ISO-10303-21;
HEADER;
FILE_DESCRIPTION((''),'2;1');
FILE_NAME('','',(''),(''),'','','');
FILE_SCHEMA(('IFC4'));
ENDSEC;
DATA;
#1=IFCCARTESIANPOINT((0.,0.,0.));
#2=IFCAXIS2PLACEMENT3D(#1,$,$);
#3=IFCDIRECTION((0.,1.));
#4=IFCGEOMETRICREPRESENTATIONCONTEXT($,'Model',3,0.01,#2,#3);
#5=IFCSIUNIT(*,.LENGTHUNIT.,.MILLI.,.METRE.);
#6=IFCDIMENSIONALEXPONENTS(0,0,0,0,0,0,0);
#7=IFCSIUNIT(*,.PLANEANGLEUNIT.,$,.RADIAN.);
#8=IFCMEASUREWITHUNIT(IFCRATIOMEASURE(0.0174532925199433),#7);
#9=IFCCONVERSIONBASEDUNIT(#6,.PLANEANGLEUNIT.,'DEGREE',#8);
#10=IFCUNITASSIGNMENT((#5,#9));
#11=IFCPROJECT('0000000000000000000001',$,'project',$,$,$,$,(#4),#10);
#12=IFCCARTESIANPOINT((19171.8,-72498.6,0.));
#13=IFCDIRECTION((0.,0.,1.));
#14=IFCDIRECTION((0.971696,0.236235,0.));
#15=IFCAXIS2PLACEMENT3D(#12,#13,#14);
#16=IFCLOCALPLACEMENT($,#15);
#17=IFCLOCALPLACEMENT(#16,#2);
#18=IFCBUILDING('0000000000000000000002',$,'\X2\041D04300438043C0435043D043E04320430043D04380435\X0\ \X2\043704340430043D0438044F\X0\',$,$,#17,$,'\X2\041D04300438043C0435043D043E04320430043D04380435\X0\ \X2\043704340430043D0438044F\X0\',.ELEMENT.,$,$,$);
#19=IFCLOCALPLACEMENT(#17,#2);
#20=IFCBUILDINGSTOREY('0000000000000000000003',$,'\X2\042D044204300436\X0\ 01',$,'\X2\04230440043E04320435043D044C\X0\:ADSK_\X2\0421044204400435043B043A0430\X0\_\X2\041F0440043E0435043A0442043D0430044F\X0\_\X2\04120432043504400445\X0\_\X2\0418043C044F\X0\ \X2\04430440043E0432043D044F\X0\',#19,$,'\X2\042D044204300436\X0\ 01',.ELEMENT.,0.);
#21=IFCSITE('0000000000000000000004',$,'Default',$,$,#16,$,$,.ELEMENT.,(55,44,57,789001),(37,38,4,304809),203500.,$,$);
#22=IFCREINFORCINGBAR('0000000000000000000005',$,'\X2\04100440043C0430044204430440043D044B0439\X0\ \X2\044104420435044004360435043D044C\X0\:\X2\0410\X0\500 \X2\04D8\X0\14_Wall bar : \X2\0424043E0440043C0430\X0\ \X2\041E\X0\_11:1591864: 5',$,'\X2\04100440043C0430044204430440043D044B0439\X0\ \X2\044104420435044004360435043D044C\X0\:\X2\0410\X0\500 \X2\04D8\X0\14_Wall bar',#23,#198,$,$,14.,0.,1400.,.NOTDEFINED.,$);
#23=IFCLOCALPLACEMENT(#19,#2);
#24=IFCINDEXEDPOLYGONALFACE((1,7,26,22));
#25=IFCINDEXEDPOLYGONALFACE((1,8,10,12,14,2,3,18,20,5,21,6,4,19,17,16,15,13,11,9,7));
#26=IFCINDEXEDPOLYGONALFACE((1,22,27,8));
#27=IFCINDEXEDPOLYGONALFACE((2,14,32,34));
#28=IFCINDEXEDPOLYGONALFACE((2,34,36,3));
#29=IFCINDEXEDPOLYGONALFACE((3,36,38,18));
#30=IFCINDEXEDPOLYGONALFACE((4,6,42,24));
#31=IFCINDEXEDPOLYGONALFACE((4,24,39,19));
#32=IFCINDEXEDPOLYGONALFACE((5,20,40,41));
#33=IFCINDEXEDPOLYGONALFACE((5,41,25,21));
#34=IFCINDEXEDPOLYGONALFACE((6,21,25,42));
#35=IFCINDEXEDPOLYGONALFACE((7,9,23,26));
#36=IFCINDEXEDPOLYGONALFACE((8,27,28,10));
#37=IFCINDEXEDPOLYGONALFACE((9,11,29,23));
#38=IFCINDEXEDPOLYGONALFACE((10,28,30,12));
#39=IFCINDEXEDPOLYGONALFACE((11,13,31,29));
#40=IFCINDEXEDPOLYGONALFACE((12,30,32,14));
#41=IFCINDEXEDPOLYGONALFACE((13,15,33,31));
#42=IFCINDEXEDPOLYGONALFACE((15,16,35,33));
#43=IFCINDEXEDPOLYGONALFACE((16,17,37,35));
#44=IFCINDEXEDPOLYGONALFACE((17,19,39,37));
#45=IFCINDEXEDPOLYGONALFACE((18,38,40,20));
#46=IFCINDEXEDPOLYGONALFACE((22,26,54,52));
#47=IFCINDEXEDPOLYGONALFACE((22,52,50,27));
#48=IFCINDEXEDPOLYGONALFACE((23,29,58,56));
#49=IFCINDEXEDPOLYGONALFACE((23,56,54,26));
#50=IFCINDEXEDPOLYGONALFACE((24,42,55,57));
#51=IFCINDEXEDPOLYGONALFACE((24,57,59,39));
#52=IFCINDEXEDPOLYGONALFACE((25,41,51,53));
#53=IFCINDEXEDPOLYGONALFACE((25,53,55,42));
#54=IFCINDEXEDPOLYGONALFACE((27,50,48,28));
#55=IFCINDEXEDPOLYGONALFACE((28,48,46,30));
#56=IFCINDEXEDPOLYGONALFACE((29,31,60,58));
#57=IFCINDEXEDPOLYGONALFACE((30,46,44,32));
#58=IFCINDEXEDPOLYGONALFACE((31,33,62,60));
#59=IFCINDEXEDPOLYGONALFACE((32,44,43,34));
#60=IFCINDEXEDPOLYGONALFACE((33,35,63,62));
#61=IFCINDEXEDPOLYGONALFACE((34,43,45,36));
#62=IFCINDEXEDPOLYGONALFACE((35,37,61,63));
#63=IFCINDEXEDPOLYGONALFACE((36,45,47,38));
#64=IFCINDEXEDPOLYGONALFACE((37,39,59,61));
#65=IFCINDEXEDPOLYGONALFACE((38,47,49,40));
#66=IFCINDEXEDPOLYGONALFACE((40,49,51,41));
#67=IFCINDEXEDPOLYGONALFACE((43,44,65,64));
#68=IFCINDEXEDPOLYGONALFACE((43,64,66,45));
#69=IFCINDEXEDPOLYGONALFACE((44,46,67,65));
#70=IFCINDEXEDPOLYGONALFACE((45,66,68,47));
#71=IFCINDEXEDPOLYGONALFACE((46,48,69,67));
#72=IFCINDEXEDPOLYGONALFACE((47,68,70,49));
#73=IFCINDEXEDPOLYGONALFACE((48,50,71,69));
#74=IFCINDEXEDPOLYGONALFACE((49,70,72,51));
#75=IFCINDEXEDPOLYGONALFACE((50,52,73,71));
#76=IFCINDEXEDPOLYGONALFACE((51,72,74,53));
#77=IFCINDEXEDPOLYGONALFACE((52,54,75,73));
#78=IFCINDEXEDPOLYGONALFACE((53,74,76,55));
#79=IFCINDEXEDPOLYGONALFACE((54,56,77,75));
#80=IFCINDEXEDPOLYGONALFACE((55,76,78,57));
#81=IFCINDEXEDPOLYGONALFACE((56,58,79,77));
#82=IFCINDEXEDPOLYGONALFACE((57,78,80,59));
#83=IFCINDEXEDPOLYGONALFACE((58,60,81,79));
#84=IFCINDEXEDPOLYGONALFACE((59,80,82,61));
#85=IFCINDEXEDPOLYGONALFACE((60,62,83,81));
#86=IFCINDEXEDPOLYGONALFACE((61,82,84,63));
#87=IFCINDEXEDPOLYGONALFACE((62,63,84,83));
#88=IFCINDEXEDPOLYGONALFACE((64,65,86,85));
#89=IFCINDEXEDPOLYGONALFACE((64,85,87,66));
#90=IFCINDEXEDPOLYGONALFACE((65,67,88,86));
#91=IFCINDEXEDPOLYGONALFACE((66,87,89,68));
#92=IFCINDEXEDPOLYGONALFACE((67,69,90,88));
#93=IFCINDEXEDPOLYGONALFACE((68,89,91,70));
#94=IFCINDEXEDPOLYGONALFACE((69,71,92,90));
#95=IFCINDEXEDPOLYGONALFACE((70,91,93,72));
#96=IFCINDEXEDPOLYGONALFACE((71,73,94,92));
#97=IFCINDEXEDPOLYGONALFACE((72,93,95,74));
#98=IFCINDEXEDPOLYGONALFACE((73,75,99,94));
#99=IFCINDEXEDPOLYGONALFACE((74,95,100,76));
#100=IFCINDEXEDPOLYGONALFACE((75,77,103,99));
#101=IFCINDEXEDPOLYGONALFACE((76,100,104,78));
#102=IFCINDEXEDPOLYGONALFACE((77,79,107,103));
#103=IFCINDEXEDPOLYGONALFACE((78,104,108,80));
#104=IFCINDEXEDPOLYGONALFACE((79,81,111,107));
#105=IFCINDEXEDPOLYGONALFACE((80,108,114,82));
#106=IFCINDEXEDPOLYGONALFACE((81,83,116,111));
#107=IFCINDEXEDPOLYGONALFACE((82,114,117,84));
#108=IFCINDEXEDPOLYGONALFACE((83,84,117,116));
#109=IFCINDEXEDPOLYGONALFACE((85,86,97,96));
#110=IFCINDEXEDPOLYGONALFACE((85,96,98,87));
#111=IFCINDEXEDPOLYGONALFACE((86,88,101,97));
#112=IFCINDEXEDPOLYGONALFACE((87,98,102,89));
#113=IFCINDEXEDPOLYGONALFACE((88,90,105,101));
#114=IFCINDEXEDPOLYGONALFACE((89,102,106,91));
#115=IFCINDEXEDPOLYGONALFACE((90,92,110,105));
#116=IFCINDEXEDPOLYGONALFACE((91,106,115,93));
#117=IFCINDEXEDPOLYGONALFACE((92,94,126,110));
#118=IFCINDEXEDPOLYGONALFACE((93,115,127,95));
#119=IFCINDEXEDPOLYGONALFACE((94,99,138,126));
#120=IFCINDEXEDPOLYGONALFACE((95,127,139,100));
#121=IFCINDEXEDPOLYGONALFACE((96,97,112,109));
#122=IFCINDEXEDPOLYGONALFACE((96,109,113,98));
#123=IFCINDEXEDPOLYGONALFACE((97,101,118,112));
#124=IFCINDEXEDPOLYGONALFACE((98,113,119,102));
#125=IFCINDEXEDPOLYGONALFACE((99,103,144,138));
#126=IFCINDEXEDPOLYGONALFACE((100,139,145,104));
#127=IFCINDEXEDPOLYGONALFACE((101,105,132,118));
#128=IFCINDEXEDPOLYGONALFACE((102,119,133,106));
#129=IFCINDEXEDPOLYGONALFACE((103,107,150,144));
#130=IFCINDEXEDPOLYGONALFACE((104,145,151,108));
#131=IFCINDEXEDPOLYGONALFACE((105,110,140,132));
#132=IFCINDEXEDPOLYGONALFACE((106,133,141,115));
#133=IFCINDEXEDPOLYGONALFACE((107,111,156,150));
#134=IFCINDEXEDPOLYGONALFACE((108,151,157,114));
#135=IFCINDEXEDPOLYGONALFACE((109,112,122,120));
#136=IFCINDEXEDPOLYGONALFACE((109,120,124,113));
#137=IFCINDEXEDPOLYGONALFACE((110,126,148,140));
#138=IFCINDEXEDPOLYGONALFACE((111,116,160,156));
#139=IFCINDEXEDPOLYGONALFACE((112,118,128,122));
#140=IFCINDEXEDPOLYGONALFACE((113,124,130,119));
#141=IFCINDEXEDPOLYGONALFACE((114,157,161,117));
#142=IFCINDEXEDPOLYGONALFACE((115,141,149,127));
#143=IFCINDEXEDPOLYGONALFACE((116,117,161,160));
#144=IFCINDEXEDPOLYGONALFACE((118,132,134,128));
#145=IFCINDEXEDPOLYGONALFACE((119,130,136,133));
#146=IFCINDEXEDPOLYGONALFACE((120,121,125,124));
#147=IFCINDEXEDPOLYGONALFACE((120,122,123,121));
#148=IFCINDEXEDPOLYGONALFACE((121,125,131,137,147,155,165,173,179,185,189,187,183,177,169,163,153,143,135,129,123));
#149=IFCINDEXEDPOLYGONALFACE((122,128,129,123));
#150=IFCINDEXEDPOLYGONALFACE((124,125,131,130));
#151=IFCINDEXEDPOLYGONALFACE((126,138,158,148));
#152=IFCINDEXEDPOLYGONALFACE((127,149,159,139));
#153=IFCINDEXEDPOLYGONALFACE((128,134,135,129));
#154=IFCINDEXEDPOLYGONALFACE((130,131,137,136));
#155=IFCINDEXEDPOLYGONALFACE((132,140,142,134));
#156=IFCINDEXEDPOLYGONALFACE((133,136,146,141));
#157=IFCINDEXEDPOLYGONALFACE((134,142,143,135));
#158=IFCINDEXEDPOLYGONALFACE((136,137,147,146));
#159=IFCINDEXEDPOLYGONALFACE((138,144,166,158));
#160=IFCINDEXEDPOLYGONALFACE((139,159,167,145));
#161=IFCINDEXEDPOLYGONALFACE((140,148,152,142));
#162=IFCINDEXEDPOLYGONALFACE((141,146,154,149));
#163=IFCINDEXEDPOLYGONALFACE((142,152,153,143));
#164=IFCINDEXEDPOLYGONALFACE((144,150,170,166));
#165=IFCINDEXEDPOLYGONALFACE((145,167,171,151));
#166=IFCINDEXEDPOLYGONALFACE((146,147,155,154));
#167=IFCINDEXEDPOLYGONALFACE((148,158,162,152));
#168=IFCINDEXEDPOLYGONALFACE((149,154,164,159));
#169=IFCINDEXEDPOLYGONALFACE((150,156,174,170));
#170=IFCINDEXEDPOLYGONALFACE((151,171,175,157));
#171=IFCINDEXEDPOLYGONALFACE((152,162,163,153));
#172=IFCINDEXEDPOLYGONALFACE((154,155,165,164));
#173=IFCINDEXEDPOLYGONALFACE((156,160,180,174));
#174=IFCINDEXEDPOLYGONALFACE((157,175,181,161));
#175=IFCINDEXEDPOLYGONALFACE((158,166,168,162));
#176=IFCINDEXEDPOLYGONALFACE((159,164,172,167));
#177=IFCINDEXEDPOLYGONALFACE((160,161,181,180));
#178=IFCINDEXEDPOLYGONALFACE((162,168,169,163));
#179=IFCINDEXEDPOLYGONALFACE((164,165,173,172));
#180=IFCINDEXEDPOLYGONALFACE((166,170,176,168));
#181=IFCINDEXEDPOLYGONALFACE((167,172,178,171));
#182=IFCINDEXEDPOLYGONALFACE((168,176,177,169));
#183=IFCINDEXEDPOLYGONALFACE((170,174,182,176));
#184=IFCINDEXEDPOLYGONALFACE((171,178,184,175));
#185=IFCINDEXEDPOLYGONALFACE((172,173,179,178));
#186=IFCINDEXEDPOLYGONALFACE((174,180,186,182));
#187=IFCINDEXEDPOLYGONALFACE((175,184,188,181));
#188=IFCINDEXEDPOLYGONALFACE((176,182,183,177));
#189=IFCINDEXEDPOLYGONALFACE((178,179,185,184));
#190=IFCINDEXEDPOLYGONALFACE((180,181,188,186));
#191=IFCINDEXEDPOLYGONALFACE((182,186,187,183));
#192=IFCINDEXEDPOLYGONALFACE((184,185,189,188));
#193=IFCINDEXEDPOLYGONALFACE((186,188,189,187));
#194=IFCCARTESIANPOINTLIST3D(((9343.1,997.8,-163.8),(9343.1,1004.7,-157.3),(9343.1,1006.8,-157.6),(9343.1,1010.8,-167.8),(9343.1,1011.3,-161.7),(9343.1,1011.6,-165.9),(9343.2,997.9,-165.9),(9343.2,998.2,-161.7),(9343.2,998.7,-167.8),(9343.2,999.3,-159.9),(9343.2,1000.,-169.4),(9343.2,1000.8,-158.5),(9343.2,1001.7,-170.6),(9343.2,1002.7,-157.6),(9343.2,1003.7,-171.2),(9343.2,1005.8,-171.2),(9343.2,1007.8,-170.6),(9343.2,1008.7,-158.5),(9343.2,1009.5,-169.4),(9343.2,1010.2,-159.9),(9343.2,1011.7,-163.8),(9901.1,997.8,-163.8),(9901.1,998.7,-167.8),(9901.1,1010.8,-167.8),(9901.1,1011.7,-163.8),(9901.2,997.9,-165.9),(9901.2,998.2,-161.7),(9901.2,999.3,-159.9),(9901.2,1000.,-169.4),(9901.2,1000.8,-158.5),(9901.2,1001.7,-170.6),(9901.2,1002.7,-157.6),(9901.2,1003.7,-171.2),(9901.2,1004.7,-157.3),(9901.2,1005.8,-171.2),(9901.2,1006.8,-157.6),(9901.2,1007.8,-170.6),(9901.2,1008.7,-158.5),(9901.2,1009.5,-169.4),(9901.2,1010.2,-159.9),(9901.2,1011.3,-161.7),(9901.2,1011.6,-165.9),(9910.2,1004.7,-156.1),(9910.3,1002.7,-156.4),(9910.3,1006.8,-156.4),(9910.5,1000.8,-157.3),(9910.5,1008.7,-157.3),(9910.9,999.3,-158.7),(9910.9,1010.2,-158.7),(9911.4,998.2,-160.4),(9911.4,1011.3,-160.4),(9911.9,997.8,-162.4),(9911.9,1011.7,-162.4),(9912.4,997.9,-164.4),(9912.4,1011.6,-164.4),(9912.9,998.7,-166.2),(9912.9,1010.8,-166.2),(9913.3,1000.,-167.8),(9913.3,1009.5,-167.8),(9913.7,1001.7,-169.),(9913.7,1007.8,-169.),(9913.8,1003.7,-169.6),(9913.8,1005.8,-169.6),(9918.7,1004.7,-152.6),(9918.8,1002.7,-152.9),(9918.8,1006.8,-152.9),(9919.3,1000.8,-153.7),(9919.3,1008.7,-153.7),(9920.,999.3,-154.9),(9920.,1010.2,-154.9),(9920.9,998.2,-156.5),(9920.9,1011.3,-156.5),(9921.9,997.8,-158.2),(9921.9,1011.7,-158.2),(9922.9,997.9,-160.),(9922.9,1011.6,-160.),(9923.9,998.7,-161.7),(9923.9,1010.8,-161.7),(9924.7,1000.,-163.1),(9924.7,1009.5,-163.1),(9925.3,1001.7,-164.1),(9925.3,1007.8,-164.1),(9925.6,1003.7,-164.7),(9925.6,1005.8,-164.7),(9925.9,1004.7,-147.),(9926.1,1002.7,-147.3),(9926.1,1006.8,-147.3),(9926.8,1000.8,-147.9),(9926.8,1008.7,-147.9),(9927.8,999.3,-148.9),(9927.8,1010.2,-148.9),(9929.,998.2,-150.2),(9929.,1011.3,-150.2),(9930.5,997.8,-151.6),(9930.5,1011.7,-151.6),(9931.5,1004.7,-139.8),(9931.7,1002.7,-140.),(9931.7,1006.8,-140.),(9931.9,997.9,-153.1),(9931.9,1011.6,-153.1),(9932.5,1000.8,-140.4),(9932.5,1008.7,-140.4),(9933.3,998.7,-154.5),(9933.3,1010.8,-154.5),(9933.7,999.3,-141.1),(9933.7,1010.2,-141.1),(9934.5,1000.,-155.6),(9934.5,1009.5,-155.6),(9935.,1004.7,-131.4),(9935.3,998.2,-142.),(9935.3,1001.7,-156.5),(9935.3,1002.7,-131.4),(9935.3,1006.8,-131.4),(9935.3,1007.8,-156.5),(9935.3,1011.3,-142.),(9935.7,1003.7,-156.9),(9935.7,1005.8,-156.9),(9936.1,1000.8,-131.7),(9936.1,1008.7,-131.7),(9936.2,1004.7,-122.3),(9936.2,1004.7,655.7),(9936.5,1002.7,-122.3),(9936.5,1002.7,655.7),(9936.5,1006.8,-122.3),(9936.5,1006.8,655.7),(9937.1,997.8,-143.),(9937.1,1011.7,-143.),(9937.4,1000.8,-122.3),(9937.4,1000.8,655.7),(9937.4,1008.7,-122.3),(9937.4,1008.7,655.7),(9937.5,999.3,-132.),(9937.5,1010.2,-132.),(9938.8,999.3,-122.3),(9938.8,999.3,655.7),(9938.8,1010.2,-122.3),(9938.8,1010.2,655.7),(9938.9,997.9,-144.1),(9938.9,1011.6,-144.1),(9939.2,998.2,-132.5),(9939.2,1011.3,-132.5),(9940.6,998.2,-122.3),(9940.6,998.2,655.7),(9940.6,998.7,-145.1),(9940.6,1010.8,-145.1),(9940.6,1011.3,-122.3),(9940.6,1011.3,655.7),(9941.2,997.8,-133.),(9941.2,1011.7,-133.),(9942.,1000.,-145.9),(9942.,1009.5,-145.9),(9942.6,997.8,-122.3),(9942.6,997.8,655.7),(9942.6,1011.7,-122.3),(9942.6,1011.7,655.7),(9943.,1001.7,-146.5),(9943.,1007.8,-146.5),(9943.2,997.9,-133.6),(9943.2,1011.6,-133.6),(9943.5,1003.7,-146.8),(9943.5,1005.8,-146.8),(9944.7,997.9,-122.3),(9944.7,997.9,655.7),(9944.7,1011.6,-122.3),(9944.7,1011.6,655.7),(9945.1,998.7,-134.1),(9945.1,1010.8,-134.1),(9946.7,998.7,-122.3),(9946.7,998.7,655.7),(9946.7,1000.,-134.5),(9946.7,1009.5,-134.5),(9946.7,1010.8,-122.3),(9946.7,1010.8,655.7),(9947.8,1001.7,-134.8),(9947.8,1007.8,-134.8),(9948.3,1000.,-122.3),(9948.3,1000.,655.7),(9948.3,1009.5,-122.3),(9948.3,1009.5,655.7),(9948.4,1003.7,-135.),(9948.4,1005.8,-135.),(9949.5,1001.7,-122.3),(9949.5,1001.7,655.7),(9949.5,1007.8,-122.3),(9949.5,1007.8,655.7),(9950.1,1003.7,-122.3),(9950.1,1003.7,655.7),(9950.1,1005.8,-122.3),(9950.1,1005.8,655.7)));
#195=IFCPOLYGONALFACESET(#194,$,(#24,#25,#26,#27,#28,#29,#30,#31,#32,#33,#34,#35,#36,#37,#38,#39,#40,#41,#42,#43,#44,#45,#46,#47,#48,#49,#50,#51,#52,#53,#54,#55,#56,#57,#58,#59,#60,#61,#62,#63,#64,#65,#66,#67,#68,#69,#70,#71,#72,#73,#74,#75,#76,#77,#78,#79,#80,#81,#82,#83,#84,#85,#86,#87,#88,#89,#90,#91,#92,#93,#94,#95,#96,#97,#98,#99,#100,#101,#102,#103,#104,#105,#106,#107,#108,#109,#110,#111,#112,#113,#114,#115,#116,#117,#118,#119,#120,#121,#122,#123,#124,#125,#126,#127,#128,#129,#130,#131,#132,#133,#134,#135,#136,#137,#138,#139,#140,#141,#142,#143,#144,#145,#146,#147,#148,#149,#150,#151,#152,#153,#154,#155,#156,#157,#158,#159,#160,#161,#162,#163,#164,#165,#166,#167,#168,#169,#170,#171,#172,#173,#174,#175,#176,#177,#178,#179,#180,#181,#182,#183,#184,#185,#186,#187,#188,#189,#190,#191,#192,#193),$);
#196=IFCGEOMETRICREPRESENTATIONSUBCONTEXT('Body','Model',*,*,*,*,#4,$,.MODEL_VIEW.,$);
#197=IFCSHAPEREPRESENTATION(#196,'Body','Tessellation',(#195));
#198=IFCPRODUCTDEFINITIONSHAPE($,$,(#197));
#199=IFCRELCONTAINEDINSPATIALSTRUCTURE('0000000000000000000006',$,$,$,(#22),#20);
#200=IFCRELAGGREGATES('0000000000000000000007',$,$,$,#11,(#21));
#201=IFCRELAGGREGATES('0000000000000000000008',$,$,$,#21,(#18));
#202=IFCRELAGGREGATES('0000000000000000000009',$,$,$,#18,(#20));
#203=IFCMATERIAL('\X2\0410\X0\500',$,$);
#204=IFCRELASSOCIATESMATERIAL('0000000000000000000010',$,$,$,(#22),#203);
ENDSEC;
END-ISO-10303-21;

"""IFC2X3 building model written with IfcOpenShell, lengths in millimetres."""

from ifc_helpers import new_model, entity, si_unit, converted_unit, direction, frame, origin, place, context, subcontext, project, spatial, material, element, save


model = new_model("IFC2X3")

# Units and contexts
model_context = context("Model", 3, precision=0.01, world=origin(), true_north=direction((0.0, 1.0)))
body_context = subcontext(model_context, "Body", "Model", "MODEL_VIEW")
ifc_project = project(units=[si_unit("LENGTHUNIT", "METRE", prefix="MILLI"), converted_unit("PLANEANGLEUNIT", "DEGREE", entity("IfcRatioMeasure", 0.0174532925199433), si_unit("PLANEANGLEUNIT", "RADIAN"), dimensions=[0, 0, 0, 0, 0, 0, 0])], contexts=[model_context])

# Site, building, storey
site_placement = place(None, frame((19171.8, -72498.6, 0.0), z_axis=(0.0, 0.0, 1.0), x_axis=(0.971696, 0.236235, 0.0)))
site = spatial("IfcSite", under=ifc_project, at=site_placement, Name="Default", CompositionType="ELEMENT", RefLatitude=(55, 44, 57, 789001), RefLongitude=(37, 38, 4, 304809), RefElevation=203500.0)
building_placement = place(site_placement, origin())
building = spatial("IfcBuilding", under=site, at=building_placement, Name="Наименование здания", LongName="Наименование здания", CompositionType="ELEMENT")
storey_placement = place(building_placement, origin())
storey = spatial("IfcBuildingStorey", under=building, at=storey_placement, Name="Этаж 01", ObjectType="Уровень:ADSK_Стрелка_Проектная_Вверх_Имя уровня", LongName="Этаж 01", CompositionType="ELEMENT", Elevation=0.0)

# Reinforcing bar
ifc_material = material(Name="А500")
placement = place(storey_placement, origin())
element("IfcReinforcingBar", 1, at=placement, inside=storey, material=ifc_material, Name="Арматурный стержень:А500 Ә14_Wall bar : Форма О_11:1591864: 5", ObjectType="Арматурный стержень:А500 Ә14_Wall bar", BarLength=1400.0, BarRole="NOTDEFINED", CrossSectionArea=0.0, NominalDiameter=14.0, context=body_context, shape_type="AdvancedSweptSolid", body=[
    entity("IfcSweptDiskSolid", entity("IfcCompositeCurve", [entity("IfcCompositeCurveSegment", "CONTINUOUS", True, entity("IfcPolyline", [entity("IfcCartesianPoint", [9943.1, 1004.7, 655.7]), entity("IfcCartesianPoint", [9943.1, 1004.7, -122.3])])), entity("IfcCompositeCurveSegment", "CONTINUOUS", True, entity("IfcTrimmedCurve", entity("IfcCircle", entity("IfcAxis2Placement3D", entity("IfcCartesianPoint", [9901.1, 1004.7, -122.3]), entity("IfcDirection", [0.0, 1.0, 0.0]), entity("IfcDirection", [0.0, 0.0, -1.0])), 42.0), [entity("IfcParameterValue", 270.0)], [entity("IfcParameterValue", 360.0)], True, "PARAMETER")), entity("IfcCompositeCurveSegment", "CONTINUOUS", True, entity("IfcPolyline", [entity("IfcCartesianPoint", [9901.1, 1004.7, -164.3]), entity("IfcCartesianPoint", [9343.1, 1004.7, -164.3])]))], False), 7.0, None, 0.0, 92.0),
])

save(model, "model.ifc")
